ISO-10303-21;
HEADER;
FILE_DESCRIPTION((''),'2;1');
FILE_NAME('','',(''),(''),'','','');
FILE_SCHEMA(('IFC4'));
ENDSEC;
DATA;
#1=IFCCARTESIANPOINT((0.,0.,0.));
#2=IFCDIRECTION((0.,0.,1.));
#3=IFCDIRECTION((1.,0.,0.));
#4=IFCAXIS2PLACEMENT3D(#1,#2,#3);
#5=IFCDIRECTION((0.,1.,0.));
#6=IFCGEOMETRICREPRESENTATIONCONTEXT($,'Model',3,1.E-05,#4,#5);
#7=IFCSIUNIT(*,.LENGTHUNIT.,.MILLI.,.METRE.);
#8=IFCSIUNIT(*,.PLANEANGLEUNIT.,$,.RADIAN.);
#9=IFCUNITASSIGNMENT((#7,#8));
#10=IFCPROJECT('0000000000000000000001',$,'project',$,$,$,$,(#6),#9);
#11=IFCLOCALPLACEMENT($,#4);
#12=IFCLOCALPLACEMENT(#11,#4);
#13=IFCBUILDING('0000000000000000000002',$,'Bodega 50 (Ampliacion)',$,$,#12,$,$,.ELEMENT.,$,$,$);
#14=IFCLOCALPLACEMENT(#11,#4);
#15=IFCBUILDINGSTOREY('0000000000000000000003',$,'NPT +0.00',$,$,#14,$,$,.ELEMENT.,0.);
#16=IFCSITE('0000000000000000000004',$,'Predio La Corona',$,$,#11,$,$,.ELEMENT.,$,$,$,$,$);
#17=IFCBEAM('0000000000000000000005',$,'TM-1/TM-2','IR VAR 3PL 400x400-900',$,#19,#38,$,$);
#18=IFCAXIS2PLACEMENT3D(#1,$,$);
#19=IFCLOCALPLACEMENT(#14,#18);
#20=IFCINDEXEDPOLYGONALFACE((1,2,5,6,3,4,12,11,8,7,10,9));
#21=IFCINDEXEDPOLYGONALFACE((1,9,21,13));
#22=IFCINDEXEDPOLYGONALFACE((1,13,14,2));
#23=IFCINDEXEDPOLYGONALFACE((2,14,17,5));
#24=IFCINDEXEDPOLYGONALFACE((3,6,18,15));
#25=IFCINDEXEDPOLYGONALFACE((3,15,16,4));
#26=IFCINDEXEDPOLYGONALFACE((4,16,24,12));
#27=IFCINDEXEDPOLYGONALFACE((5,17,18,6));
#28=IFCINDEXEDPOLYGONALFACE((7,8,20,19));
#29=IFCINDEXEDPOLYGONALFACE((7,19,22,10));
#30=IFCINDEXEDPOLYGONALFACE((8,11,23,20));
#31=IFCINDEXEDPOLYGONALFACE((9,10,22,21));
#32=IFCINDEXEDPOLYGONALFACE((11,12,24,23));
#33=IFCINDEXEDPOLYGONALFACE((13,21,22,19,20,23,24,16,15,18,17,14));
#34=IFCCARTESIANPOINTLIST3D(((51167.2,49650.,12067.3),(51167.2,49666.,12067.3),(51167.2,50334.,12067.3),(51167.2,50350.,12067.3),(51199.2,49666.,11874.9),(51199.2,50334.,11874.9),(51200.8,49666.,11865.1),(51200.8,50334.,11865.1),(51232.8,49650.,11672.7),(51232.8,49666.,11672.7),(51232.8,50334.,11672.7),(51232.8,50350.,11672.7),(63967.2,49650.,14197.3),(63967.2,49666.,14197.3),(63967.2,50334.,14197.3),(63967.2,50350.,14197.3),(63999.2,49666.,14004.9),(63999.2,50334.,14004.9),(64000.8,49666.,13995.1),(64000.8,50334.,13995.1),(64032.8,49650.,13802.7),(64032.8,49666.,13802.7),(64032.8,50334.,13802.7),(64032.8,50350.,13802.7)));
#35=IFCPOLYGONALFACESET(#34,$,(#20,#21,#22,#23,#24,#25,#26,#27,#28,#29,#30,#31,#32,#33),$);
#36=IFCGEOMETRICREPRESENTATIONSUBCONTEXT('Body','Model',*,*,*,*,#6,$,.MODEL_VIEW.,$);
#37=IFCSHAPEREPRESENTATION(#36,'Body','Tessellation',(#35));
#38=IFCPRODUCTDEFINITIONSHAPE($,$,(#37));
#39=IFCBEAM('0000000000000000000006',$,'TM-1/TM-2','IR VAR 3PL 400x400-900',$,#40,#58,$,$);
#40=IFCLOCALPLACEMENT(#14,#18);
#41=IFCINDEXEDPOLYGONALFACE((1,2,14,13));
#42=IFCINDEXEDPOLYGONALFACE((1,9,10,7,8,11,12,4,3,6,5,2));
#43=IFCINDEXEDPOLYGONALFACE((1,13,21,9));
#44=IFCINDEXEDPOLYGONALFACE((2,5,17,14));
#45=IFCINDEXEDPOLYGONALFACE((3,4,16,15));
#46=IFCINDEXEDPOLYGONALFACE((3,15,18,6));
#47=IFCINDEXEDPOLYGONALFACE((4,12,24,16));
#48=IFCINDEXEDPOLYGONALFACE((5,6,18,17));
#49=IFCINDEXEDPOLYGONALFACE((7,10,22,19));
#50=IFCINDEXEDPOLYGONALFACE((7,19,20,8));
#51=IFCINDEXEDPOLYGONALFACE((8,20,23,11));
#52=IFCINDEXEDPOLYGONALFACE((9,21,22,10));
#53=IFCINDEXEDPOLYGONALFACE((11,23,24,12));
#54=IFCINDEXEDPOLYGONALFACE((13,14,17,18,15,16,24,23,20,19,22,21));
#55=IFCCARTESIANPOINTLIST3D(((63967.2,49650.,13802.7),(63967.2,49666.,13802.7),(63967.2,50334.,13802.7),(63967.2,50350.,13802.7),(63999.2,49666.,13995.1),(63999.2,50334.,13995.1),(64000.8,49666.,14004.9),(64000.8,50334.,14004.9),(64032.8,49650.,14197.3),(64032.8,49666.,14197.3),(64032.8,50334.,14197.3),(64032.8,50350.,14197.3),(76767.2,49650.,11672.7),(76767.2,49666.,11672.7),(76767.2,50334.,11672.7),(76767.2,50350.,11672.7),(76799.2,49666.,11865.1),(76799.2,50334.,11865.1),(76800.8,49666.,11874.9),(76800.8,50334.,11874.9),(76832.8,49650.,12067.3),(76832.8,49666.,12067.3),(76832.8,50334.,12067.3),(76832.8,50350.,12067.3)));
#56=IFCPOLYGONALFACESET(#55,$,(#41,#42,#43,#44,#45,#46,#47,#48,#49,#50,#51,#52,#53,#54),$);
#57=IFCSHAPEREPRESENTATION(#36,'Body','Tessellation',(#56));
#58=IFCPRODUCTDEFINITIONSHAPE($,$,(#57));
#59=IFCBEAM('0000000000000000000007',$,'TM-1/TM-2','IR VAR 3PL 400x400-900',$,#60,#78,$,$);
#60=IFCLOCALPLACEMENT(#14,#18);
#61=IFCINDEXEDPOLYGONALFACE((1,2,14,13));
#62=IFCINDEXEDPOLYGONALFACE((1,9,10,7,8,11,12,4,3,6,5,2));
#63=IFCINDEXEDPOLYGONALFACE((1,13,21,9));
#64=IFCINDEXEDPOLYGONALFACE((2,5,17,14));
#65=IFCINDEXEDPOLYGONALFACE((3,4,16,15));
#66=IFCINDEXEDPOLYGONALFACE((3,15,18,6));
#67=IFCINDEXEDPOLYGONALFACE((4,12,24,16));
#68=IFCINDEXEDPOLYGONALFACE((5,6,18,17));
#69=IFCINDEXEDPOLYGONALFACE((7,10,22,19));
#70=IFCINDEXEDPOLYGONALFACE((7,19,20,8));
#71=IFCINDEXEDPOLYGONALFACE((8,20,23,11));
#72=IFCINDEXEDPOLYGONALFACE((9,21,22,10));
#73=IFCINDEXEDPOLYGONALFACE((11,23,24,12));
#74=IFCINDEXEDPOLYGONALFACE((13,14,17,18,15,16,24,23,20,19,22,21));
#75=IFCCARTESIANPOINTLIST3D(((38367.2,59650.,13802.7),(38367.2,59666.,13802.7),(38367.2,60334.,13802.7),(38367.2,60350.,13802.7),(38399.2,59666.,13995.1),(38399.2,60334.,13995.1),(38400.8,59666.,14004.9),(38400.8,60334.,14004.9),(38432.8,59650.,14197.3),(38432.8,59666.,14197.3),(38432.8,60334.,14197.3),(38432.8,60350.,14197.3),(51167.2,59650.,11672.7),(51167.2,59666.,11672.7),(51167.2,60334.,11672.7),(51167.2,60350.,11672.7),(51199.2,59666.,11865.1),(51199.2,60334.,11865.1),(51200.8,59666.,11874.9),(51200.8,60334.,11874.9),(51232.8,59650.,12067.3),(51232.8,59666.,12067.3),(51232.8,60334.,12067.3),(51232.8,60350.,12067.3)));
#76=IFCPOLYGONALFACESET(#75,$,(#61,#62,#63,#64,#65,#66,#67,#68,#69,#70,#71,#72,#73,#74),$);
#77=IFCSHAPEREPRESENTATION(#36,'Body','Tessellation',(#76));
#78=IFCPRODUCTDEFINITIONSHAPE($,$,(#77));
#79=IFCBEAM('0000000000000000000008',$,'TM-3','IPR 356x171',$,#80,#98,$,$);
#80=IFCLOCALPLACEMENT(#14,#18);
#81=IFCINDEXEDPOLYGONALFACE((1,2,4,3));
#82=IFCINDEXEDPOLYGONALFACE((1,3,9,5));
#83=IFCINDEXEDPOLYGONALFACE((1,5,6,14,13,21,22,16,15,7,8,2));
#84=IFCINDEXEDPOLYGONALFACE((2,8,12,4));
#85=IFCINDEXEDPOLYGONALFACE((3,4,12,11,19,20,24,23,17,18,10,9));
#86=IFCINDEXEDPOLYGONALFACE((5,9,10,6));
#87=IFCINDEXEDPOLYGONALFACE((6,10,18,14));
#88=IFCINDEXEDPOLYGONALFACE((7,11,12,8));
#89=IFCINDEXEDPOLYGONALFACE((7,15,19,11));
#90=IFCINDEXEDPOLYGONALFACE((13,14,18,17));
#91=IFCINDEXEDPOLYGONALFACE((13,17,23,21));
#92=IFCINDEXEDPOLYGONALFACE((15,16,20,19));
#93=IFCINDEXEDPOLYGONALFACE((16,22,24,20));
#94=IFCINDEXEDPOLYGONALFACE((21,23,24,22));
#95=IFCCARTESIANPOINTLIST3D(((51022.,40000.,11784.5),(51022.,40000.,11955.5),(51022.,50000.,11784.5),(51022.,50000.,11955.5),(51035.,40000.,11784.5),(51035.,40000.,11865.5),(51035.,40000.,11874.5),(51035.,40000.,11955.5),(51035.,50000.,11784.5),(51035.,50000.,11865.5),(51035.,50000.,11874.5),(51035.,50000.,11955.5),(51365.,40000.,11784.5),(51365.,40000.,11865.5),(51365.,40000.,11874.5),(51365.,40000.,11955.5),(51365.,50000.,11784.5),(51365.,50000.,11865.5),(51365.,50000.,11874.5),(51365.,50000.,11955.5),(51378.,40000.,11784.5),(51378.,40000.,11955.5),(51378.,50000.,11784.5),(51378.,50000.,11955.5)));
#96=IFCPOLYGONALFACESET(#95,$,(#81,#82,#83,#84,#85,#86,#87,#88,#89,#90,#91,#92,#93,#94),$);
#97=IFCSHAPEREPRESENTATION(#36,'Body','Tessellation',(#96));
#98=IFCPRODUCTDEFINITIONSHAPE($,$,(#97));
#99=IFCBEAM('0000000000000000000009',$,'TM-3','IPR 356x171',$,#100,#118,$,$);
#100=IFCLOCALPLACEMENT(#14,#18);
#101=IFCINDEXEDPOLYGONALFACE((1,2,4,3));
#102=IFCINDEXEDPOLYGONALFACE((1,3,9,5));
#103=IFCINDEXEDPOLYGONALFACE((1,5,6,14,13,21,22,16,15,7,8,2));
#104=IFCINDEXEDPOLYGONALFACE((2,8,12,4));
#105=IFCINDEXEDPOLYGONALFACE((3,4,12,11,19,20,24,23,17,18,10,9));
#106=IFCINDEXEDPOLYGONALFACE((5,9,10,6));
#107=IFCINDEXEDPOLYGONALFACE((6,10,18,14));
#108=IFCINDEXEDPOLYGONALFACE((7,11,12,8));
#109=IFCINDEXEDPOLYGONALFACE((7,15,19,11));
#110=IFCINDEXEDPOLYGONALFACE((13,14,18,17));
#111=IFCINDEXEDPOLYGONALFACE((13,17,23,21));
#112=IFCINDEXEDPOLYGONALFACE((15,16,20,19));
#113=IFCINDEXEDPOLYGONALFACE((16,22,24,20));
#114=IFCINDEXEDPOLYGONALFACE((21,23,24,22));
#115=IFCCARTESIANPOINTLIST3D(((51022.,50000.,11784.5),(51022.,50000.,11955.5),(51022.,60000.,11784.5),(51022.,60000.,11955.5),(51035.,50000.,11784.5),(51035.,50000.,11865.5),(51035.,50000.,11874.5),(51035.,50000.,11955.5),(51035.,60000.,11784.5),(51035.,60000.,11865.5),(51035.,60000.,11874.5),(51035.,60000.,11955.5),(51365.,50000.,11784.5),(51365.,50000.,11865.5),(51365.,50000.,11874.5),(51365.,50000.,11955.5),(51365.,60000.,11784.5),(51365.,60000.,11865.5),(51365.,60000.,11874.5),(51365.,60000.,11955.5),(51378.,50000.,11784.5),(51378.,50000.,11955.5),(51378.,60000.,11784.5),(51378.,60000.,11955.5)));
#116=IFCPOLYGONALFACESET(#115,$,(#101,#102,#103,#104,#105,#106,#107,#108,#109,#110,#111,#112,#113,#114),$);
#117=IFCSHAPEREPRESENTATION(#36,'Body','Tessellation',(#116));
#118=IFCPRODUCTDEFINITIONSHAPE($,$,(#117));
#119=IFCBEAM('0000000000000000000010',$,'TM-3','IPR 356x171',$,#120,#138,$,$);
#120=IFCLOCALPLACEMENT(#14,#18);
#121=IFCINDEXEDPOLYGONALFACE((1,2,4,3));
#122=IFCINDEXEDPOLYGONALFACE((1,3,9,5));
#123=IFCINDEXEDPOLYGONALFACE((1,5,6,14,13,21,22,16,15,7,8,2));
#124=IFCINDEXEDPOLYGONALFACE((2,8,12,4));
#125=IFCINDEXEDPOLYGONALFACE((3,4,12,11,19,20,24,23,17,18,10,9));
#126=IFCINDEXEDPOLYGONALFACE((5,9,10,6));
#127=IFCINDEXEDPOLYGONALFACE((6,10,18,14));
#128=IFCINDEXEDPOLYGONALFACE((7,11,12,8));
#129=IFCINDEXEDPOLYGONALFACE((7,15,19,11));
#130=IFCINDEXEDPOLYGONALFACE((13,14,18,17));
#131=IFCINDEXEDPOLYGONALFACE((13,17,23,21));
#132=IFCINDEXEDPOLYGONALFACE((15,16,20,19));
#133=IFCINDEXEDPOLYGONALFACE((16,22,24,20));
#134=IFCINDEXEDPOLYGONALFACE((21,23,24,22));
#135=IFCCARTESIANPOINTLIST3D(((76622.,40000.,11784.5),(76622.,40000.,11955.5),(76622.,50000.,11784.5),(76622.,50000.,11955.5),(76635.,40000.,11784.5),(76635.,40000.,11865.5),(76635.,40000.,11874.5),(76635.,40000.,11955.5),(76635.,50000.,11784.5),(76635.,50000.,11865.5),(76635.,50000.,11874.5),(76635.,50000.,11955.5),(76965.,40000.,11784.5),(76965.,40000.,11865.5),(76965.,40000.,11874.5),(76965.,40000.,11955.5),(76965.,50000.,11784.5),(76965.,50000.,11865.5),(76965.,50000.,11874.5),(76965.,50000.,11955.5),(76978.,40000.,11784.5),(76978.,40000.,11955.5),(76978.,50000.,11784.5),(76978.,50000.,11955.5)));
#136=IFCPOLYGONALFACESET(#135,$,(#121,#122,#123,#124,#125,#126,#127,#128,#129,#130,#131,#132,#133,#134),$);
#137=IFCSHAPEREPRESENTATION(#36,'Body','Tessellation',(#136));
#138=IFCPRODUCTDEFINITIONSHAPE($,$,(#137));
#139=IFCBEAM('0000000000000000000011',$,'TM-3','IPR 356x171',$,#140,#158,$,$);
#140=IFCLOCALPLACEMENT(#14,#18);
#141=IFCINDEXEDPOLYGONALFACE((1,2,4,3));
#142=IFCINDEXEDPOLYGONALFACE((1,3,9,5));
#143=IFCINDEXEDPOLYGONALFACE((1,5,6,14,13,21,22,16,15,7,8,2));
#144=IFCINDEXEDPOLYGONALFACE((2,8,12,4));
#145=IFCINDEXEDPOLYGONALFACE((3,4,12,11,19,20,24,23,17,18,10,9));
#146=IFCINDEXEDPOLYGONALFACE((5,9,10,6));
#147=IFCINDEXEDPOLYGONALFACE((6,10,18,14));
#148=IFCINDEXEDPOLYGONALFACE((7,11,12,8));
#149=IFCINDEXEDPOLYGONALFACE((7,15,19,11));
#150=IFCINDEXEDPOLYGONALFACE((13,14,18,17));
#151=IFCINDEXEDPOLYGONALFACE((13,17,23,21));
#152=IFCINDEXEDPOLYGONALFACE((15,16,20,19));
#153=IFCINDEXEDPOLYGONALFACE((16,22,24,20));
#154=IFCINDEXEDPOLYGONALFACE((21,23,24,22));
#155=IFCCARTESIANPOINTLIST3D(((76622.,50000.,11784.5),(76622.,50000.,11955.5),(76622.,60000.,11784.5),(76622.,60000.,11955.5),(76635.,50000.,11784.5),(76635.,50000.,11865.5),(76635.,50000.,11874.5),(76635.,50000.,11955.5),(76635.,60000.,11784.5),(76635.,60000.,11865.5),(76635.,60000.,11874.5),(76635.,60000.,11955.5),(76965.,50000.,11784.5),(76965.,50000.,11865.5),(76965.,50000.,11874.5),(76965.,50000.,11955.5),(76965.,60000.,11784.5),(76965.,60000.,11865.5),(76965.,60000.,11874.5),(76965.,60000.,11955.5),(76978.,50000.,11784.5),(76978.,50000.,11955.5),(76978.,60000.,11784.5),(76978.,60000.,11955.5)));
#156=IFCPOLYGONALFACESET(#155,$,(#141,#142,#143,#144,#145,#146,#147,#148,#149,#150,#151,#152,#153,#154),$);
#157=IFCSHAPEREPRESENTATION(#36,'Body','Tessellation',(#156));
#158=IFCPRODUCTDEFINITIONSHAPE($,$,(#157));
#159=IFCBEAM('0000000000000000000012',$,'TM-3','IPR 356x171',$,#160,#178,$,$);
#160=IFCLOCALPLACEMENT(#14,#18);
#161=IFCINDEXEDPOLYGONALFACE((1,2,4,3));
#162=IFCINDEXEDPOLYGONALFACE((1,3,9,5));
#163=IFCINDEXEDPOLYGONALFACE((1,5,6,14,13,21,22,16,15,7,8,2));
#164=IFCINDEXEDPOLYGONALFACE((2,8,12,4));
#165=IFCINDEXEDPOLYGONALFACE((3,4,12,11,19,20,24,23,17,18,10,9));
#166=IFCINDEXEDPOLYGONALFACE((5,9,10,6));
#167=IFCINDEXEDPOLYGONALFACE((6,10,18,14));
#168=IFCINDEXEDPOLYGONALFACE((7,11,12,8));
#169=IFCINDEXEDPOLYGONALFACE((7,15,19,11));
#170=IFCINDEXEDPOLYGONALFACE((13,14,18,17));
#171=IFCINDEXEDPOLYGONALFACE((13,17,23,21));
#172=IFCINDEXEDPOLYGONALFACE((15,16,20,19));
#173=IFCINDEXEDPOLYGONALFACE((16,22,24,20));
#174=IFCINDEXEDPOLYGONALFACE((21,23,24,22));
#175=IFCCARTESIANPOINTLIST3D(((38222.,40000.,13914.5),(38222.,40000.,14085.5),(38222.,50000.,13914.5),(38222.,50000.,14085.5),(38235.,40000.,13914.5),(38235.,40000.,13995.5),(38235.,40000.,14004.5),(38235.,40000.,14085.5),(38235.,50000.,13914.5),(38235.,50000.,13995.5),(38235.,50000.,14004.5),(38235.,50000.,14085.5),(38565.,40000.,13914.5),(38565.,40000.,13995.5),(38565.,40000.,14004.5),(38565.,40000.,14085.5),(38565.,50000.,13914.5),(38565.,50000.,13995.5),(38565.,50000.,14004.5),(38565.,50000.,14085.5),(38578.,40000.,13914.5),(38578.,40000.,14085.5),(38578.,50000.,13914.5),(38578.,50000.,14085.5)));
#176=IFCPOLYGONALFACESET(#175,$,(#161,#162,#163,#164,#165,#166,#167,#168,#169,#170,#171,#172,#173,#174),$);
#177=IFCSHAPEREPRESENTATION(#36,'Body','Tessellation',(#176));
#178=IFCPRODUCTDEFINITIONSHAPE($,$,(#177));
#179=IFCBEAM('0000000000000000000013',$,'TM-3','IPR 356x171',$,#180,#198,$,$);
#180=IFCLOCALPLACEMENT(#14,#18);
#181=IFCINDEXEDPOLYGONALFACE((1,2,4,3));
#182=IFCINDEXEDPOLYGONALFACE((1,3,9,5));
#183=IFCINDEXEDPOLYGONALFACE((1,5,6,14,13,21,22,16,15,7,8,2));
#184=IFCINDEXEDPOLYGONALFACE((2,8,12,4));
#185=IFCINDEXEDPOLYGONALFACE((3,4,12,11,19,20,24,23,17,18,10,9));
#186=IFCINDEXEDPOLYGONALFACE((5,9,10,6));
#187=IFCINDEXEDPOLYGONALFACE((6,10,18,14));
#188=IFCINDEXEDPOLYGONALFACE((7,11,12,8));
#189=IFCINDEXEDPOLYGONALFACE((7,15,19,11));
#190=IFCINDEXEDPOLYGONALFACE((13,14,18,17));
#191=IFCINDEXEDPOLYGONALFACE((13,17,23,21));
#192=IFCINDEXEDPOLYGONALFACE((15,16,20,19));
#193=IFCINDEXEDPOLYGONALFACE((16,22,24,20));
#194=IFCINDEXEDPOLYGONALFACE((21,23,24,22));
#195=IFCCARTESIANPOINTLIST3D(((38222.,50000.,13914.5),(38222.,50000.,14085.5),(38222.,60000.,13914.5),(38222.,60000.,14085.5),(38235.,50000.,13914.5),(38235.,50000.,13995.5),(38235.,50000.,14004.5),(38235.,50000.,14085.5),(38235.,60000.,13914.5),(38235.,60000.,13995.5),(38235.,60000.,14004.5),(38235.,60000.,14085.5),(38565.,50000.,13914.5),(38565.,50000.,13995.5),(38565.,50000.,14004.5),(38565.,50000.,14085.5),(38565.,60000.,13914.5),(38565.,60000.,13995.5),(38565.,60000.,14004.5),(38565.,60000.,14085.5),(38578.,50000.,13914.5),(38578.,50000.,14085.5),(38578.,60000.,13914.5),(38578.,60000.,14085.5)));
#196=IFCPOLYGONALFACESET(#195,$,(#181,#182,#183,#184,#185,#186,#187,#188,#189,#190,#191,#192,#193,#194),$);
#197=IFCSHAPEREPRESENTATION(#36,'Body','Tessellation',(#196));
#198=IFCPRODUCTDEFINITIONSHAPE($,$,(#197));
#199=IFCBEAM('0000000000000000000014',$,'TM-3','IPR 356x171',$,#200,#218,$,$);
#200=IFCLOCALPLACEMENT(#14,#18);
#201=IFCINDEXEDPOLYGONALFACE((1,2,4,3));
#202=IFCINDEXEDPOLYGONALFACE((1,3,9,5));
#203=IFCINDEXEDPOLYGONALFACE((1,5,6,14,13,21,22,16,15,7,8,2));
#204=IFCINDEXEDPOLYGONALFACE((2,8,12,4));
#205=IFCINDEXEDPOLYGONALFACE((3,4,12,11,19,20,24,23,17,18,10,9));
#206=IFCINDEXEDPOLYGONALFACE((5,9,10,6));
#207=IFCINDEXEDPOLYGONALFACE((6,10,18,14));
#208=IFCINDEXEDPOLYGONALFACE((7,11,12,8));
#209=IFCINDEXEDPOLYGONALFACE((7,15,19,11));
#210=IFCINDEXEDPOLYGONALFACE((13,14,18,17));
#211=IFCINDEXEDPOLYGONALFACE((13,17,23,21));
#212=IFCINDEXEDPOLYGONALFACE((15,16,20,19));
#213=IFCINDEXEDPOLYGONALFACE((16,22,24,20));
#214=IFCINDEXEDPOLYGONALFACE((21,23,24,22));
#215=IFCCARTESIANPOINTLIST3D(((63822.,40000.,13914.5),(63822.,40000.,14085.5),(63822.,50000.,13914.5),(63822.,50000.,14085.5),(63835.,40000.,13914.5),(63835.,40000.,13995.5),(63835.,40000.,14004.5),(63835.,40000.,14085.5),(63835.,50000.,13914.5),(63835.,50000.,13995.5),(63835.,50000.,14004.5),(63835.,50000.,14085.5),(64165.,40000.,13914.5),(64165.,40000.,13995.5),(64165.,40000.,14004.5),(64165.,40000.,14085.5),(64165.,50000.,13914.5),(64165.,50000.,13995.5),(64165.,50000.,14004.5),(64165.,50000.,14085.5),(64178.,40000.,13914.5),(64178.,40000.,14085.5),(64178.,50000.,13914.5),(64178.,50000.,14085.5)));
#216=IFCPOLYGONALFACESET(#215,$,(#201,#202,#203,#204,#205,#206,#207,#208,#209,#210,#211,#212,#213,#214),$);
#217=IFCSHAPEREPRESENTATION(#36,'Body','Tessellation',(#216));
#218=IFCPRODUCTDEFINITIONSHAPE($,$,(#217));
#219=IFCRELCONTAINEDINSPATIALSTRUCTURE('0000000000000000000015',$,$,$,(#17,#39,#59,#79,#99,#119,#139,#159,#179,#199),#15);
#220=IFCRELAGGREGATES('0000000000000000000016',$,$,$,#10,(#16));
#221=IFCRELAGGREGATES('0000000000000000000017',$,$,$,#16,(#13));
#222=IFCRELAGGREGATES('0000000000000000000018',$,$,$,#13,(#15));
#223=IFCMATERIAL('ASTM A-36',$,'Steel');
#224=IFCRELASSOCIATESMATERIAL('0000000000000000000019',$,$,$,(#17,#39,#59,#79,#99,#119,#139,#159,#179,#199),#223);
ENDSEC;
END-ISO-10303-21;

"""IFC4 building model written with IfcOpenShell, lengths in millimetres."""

from ifc_helpers import new_model, si_unit, direction, frame, origin_with_axes, origin_2d, place, context, subcontext, project, spatial, i_section, extrude, material, element, save


model = new_model("IFC4")

# Units and contexts
model_context = context("Model", 3, precision=1e-05, world=origin_with_axes(), true_north=direction((0.0, 1.0, 0.0)))
body_context = subcontext(model_context, "Body", "Model", "MODEL_VIEW")
ifc_project = project(units=[si_unit("LENGTHUNIT", "METRE", prefix="MILLI"), si_unit("PLANEANGLEUNIT", "RADIAN")], contexts=[model_context])

# Site, building, storey
site_placement = place(None, origin_with_axes())
site = spatial("IfcSite", under=ifc_project, at=site_placement, Name="Predio La Corona", CompositionType="ELEMENT")
building_placement = place(site_placement, origin_with_axes())
building = spatial("IfcBuilding", under=site, at=building_placement, Name="Bodega 50 (Ampliacion)", CompositionType="ELEMENT")
storey_placement = place(site_placement, origin_with_axes())
storey = spatial("IfcBuildingStorey", under=building, at=storey_placement, Name="NPT +0.00", CompositionType="ELEMENT", Elevation=0.0)

# Shared definitions
ifc_material = material(Name="ASTM A-36", Category="Steel")

# Beams
for number, where, z_axis, x_axis, name in (
    (1, (51200.0, 50000.0, 11870.0), (0.986436, 0.0, 0.164149), (0.164149, 0.0, -0.986436), "TM-1/TM-2"),
    (2, (64000.0, 50000.0, 14000.0), (0.986436, 0.0, -0.164149), (-0.164149, 0.0, -0.986436), "TM-1/TM-2"),
    (3, (38400.0, 60000.0, 14000.0), (0.986436, 0.0, -0.164149), (-0.164149, 0.0, -0.986436), "TM-1/TM-2"),
):
    element("IfcBeam", number, at=place(storey_placement, frame(where, z_axis=z_axis, x_axis=x_axis)), inside=storey, material=ifc_material, Name=name, Description="IR VAR 3PL 400x400-900", context=body_context, shape_type="SweptSolid", body=[
        extrude(i_section(OverallWidth=400.0, OverallDepth=700.0, WebThickness=10.0, FlangeThickness=16.0, at=origin_2d()), origin_with_axes(), (0.0, 0.0, 1.0), 12976.0),
    ])
for number, where, z_axis, x_axis, name in (
    (4, (51200.0, 40000.0, 11870.0), (0.0, 1.0, 0.0), (0.0, 0.0, 1.0), "TM-3"),
    (5, (51200.0, 50000.0, 11870.0), (0.0, 1.0, 0.0), (0.0, 0.0, 1.0), "TM-3"),
    (6, (76800.0, 40000.0, 11870.0), (0.0, 1.0, 0.0), (0.0, 0.0, 1.0), "TM-3"),
    (7, (76800.0, 50000.0, 11870.0), (0.0, 1.0, 0.0), (0.0, 0.0, 1.0), "TM-3"),
    (8, (38400.0, 40000.0, 14000.0), (0.0, 1.0, 0.0), (0.0, 0.0, 1.0), "TM-3"),
    (9, (38400.0, 50000.0, 14000.0), (0.0, 1.0, 0.0), (0.0, 0.0, 1.0), "TM-3"),
    (10, (64000.0, 40000.0, 14000.0), (0.0, 1.0, 0.0), (0.0, 0.0, 1.0), "TM-3"),
):
    element("IfcBeam", number, at=place(storey_placement, frame(where, z_axis=z_axis, x_axis=x_axis)), inside=storey, material=ifc_material, Name=name, Description="IPR 356x171", context=body_context, shape_type="SweptSolid", body=[
        extrude(i_section(OverallWidth=171.0, OverallDepth=356.0, WebThickness=9.0, FlangeThickness=13.0, at=origin_2d()), origin_with_axes(), (0.0, 0.0, 1.0), 10000.0),
    ])

save(model, "model.ifc")
